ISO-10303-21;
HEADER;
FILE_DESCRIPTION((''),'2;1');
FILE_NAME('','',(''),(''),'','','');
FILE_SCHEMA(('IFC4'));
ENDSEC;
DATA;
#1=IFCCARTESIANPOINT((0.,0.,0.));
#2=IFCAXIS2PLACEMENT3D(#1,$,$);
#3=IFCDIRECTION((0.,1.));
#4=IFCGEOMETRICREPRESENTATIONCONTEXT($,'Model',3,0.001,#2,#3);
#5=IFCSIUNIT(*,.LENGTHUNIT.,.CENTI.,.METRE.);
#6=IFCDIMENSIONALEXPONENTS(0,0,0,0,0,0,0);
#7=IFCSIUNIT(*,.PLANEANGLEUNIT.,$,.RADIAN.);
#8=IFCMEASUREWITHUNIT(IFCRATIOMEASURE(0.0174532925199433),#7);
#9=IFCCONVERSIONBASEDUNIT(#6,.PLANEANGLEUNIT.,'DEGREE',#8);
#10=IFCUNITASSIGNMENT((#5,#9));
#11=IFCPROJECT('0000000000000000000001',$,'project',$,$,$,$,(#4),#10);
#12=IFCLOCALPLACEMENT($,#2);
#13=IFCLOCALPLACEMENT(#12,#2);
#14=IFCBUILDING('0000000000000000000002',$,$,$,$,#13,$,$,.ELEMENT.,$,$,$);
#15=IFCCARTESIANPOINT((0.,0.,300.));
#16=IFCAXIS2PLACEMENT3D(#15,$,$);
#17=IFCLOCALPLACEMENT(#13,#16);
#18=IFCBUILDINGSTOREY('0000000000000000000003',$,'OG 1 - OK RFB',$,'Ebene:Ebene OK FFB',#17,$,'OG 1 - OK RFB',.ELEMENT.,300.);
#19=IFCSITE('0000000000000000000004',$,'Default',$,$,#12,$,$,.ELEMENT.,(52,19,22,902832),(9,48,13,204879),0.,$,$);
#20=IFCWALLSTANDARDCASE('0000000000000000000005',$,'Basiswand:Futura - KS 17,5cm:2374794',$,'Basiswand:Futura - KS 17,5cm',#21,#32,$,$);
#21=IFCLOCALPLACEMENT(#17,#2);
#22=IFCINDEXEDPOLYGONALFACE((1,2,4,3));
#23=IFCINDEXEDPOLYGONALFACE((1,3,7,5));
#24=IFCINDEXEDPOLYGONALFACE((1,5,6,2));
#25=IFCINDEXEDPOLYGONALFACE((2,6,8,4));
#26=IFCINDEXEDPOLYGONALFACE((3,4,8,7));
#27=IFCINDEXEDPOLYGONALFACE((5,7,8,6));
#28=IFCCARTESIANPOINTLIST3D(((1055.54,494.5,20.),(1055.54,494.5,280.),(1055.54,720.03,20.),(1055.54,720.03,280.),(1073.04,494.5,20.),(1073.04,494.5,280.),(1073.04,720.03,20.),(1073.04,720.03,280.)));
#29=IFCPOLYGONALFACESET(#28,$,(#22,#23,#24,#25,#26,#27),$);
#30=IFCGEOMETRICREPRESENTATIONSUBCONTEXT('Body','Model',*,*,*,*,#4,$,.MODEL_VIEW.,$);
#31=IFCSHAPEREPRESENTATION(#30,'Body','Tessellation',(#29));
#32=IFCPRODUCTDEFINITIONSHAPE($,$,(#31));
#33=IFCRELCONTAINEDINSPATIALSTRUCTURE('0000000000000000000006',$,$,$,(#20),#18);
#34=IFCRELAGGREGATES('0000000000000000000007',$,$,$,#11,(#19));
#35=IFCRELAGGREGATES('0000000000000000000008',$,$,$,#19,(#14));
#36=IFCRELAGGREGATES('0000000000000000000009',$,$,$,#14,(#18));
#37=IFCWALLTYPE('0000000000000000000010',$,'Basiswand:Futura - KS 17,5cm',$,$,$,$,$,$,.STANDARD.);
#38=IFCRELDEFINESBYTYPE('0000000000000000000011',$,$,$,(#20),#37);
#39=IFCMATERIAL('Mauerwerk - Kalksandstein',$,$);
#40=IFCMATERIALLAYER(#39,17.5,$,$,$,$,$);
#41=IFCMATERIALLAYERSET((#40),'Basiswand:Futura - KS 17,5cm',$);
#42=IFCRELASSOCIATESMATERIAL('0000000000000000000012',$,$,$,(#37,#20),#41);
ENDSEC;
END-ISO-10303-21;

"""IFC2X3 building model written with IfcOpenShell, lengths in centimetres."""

from ifc_helpers import new_model, entity, si_unit, converted_unit, direction, frame, frame_2d, origin, place, context, subcontext, project, spatial, polyline, rectangle, extrude, clip, bounded_halfspace, material, layer, layer_set, layer_usage, type_object, element, save


model = new_model("IFC2X3")

# Units and contexts
model_context = context("Model", 3, precision=0.001, world=origin(), true_north=direction((0.0, 1.0)))
body_context = subcontext(model_context, "Body", "Model", "MODEL_VIEW")
ifc_project = project(units=[si_unit("LENGTHUNIT", "METRE", prefix="CENTI"), converted_unit("PLANEANGLEUNIT", "DEGREE", entity("IfcRatioMeasure", 0.0174532925199433), si_unit("PLANEANGLEUNIT", "RADIAN"), dimensions=[0, 0, 0, 0, 0, 0, 0])], contexts=[model_context])

# Site, building, storey
site_placement = place(None, frame((0.0, 0.0, 0.0)))
site = spatial("IfcSite", under=ifc_project, at=site_placement, Name="Default", CompositionType="ELEMENT", RefLatitude=(52, 19, 22, 902832), RefLongitude=(9, 48, 13, 204879), RefElevation=0.0)
building_placement = place(site_placement, origin())
building = spatial("IfcBuilding", under=site, at=building_placement, CompositionType="ELEMENT")
storey_placement = place(building_placement, frame((0.0, 0.0, 300.0)))
storey = spatial("IfcBuildingStorey", under=building, at=storey_placement, Name="OG 1 - OK RFB", ObjectType="Ebene:Ebene OK FFB", LongName="OG 1 - OK RFB", CompositionType="ELEMENT", Elevation=300.0)

# Wall
ifc_material = material(Name="Mauerwerk - Kalksandstein")
ifc_layer = layer(ifc_material, 17.5)
ifc_layer_set = layer_set([ifc_layer], Name="Basiswand:Futura - KS 17,5cm")
ifc_layer_usage = layer_usage(ifc_layer_set, "AXIS2", "NEGATIVE", 8.75)
wall_type = type_object("IfcWallType", Name="Basiswand:Futura - KS 17,5cm", PredefinedType="STANDARD", material=ifc_layer_set)
wall_placement = place(storey_placement, frame((1064.29, 720.03, 20.0), z_axis=(0.0, 0.0, 1.0), x_axis=(0.0, -1.0, 0.0)))
element("IfcWallStandardCase", 1, at=wall_placement, inside=storey, type_object=wall_type, material=ifc_layer_usage, Name="Basiswand:Futura - KS 17,5cm:2374794", ObjectType="Basiswand:Futura - KS 17,5cm", context=body_context, shape_type="Clipping", body=[
    clip(extrude(rectangle(XDim=225.54, YDim=17.5, at=frame_2d((112.77, 0.0), x_axis=(-1.0, 0.0))), origin(), (0.0, 0.0, 1.0), 260.0), bounded_halfspace(frame((225.54, -8.75, 0.0), z_axis=(0.0, 0.0, 1.0), x_axis=(-1.0, 0.0, 0.0)), True, frame((225.54, -8.75, 0.0), z_axis=(0.0, 0.0, 1.0), x_axis=(-1.0, 0.0, 0.0)), polyline([(0.0, 0.0), (0.0, -17.5), (17.5, -17.5), (225.54, -17.5), (225.54, 0.0), (0.0, 0.0)]))),
])

save(model, "model.ifc")
